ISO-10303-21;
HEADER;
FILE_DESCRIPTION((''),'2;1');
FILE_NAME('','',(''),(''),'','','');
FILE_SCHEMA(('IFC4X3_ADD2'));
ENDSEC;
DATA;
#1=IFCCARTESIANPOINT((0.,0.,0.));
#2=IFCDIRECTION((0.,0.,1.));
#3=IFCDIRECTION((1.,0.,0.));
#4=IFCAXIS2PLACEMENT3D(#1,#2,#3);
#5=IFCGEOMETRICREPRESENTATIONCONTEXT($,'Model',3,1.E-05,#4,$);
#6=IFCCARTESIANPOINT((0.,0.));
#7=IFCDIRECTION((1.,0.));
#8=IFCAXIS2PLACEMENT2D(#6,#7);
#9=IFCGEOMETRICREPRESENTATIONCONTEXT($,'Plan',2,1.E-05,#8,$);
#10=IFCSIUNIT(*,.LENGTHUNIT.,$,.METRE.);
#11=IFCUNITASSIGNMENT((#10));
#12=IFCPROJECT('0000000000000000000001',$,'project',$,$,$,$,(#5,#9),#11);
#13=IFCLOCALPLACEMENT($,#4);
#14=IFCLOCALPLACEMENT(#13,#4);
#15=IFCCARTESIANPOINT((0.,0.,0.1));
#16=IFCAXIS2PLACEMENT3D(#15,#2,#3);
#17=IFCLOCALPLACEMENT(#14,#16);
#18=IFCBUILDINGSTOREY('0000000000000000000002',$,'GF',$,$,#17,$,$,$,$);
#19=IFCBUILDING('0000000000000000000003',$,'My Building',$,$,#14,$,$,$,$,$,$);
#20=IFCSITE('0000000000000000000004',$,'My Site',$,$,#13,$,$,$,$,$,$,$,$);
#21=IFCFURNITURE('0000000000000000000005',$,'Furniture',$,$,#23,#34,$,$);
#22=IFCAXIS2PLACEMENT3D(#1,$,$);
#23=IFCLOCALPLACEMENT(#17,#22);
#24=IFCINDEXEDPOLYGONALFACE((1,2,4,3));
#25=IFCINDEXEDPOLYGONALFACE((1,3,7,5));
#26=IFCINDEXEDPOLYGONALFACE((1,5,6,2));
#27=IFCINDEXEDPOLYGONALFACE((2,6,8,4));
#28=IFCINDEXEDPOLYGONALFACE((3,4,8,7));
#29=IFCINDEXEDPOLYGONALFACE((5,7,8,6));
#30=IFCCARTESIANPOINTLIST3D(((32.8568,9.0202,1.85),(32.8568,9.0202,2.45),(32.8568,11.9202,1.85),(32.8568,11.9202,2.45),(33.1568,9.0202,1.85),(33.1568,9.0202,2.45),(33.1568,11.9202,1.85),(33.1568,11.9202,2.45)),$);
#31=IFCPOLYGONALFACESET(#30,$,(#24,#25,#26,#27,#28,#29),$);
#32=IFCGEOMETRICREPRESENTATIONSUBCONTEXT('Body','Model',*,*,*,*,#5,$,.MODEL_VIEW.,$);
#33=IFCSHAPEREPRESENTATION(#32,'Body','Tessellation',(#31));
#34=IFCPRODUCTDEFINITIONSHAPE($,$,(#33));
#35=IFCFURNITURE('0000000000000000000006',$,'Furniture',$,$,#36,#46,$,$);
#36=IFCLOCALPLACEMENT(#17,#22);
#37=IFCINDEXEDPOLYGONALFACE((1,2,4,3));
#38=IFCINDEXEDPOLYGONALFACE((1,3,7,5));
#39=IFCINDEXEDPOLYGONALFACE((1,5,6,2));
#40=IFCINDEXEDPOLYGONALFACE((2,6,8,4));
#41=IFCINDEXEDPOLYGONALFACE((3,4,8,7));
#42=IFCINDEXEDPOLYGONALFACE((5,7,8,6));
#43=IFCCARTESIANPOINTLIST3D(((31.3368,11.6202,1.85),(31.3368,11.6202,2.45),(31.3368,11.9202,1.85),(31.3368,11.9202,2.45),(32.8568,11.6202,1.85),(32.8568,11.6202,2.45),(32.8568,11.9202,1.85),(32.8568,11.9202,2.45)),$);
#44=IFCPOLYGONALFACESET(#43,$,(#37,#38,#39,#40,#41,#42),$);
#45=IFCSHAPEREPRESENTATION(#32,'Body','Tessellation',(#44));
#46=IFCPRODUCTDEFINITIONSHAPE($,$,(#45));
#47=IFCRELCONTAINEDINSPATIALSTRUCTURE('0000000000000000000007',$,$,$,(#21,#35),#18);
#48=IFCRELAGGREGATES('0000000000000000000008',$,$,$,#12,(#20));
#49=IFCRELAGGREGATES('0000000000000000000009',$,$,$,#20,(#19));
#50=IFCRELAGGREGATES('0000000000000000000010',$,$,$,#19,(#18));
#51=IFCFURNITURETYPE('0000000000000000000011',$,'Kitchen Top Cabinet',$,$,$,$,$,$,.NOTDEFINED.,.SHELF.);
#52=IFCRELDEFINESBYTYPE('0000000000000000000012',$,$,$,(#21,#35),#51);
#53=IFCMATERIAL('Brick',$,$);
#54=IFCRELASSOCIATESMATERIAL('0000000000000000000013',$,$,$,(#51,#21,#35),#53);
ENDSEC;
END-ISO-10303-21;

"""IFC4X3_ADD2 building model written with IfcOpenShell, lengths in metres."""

from ifc_helpers import new_model, si_unit, frame, origin_with_axes, origin_2d_with_axis, place, context, subcontext, project, spatial, rectangle, extrude, material, material_profile, profile_set, profile_usage, type_object, element, save


model = new_model("IFC4X3_ADD2")

# Units and contexts
model_context = context("Model", 3, precision=1e-05, world=origin_with_axes())
plan_context = context("Plan", 2, precision=1e-05, world=origin_2d_with_axis())
body_context_1 = subcontext(model_context, "Body", "Model", "MODEL_VIEW")
ifc_project = project(units=[si_unit("LENGTHUNIT", "METRE")], contexts=[model_context, plan_context])

# Site, building, storey
site_placement = place(None, origin_with_axes())
site = spatial("IfcSite", under=ifc_project, at=site_placement, Name="My Site")
building_placement = place(site_placement, origin_with_axes())
building = spatial("IfcBuilding", under=site, at=building_placement, Name="My Building")
storey_placement = place(building_placement, frame((0.0, 0.0, 0.1), z_axis=(0.0, 0.0, 1.0), x_axis=(1.0, 0.0, 0.0)))
storey = spatial("IfcBuildingStorey", under=building, at=storey_placement, Name="GF")

# Shared definitions
ifc_material_1 = material(Name="Brick")

# Furniture
ifc_material_profile_1 = material_profile(ifc_material_1, rectangle(XDim=0.3, YDim=0.6))
ifc_profile_set_1 = profile_set([ifc_material_profile_1], Name="blank")
furniture_type_1 = type_object("IfcFurnitureType", Name="Kitchen Top Cabinet", AssemblyPlace="NOTDEFINED", PredefinedType="SHELF", material=ifc_profile_set_1)
ifc_profile_usage_1 = profile_usage(ifc_profile_set_1, cardinal=5)
furniture_1_placement = place(storey_placement, frame((33.0068, 11.9202, 2.15), z_axis=(0.0, -1.0, 0.0), x_axis=(1.0, 0.0, 0.0)))
element("IfcFurniture", 1, at=furniture_1_placement, inside=storey, type_object=furniture_type_1, material=ifc_profile_usage_1, Name="Furniture", context=body_context_1, shape_type="SweptSolid", body=[
    extrude(rectangle(XDim=0.3, YDim=0.6), origin_with_axes(), (0.0, 0.0, 1.0), 2.9),
])
ifc_profile_usage_2 = profile_usage(ifc_profile_set_1, cardinal=5)
furniture_2_placement = place(storey_placement, frame((32.8568, 11.7702, 2.15), z_axis=(-1.0, 0.0, 0.0), x_axis=(0.0, -1.0, 0.0)))
element("IfcFurniture", 2, at=furniture_2_placement, inside=storey, type_object=furniture_type_1, material=ifc_profile_usage_2, Name="Furniture", context=body_context_1, shape_type="SweptSolid", body=[
    extrude(rectangle(XDim=0.3, YDim=0.6), origin_with_axes(), (0.0, 0.0, 1.0), 1.52),
])

save(model, "model.ifc")
